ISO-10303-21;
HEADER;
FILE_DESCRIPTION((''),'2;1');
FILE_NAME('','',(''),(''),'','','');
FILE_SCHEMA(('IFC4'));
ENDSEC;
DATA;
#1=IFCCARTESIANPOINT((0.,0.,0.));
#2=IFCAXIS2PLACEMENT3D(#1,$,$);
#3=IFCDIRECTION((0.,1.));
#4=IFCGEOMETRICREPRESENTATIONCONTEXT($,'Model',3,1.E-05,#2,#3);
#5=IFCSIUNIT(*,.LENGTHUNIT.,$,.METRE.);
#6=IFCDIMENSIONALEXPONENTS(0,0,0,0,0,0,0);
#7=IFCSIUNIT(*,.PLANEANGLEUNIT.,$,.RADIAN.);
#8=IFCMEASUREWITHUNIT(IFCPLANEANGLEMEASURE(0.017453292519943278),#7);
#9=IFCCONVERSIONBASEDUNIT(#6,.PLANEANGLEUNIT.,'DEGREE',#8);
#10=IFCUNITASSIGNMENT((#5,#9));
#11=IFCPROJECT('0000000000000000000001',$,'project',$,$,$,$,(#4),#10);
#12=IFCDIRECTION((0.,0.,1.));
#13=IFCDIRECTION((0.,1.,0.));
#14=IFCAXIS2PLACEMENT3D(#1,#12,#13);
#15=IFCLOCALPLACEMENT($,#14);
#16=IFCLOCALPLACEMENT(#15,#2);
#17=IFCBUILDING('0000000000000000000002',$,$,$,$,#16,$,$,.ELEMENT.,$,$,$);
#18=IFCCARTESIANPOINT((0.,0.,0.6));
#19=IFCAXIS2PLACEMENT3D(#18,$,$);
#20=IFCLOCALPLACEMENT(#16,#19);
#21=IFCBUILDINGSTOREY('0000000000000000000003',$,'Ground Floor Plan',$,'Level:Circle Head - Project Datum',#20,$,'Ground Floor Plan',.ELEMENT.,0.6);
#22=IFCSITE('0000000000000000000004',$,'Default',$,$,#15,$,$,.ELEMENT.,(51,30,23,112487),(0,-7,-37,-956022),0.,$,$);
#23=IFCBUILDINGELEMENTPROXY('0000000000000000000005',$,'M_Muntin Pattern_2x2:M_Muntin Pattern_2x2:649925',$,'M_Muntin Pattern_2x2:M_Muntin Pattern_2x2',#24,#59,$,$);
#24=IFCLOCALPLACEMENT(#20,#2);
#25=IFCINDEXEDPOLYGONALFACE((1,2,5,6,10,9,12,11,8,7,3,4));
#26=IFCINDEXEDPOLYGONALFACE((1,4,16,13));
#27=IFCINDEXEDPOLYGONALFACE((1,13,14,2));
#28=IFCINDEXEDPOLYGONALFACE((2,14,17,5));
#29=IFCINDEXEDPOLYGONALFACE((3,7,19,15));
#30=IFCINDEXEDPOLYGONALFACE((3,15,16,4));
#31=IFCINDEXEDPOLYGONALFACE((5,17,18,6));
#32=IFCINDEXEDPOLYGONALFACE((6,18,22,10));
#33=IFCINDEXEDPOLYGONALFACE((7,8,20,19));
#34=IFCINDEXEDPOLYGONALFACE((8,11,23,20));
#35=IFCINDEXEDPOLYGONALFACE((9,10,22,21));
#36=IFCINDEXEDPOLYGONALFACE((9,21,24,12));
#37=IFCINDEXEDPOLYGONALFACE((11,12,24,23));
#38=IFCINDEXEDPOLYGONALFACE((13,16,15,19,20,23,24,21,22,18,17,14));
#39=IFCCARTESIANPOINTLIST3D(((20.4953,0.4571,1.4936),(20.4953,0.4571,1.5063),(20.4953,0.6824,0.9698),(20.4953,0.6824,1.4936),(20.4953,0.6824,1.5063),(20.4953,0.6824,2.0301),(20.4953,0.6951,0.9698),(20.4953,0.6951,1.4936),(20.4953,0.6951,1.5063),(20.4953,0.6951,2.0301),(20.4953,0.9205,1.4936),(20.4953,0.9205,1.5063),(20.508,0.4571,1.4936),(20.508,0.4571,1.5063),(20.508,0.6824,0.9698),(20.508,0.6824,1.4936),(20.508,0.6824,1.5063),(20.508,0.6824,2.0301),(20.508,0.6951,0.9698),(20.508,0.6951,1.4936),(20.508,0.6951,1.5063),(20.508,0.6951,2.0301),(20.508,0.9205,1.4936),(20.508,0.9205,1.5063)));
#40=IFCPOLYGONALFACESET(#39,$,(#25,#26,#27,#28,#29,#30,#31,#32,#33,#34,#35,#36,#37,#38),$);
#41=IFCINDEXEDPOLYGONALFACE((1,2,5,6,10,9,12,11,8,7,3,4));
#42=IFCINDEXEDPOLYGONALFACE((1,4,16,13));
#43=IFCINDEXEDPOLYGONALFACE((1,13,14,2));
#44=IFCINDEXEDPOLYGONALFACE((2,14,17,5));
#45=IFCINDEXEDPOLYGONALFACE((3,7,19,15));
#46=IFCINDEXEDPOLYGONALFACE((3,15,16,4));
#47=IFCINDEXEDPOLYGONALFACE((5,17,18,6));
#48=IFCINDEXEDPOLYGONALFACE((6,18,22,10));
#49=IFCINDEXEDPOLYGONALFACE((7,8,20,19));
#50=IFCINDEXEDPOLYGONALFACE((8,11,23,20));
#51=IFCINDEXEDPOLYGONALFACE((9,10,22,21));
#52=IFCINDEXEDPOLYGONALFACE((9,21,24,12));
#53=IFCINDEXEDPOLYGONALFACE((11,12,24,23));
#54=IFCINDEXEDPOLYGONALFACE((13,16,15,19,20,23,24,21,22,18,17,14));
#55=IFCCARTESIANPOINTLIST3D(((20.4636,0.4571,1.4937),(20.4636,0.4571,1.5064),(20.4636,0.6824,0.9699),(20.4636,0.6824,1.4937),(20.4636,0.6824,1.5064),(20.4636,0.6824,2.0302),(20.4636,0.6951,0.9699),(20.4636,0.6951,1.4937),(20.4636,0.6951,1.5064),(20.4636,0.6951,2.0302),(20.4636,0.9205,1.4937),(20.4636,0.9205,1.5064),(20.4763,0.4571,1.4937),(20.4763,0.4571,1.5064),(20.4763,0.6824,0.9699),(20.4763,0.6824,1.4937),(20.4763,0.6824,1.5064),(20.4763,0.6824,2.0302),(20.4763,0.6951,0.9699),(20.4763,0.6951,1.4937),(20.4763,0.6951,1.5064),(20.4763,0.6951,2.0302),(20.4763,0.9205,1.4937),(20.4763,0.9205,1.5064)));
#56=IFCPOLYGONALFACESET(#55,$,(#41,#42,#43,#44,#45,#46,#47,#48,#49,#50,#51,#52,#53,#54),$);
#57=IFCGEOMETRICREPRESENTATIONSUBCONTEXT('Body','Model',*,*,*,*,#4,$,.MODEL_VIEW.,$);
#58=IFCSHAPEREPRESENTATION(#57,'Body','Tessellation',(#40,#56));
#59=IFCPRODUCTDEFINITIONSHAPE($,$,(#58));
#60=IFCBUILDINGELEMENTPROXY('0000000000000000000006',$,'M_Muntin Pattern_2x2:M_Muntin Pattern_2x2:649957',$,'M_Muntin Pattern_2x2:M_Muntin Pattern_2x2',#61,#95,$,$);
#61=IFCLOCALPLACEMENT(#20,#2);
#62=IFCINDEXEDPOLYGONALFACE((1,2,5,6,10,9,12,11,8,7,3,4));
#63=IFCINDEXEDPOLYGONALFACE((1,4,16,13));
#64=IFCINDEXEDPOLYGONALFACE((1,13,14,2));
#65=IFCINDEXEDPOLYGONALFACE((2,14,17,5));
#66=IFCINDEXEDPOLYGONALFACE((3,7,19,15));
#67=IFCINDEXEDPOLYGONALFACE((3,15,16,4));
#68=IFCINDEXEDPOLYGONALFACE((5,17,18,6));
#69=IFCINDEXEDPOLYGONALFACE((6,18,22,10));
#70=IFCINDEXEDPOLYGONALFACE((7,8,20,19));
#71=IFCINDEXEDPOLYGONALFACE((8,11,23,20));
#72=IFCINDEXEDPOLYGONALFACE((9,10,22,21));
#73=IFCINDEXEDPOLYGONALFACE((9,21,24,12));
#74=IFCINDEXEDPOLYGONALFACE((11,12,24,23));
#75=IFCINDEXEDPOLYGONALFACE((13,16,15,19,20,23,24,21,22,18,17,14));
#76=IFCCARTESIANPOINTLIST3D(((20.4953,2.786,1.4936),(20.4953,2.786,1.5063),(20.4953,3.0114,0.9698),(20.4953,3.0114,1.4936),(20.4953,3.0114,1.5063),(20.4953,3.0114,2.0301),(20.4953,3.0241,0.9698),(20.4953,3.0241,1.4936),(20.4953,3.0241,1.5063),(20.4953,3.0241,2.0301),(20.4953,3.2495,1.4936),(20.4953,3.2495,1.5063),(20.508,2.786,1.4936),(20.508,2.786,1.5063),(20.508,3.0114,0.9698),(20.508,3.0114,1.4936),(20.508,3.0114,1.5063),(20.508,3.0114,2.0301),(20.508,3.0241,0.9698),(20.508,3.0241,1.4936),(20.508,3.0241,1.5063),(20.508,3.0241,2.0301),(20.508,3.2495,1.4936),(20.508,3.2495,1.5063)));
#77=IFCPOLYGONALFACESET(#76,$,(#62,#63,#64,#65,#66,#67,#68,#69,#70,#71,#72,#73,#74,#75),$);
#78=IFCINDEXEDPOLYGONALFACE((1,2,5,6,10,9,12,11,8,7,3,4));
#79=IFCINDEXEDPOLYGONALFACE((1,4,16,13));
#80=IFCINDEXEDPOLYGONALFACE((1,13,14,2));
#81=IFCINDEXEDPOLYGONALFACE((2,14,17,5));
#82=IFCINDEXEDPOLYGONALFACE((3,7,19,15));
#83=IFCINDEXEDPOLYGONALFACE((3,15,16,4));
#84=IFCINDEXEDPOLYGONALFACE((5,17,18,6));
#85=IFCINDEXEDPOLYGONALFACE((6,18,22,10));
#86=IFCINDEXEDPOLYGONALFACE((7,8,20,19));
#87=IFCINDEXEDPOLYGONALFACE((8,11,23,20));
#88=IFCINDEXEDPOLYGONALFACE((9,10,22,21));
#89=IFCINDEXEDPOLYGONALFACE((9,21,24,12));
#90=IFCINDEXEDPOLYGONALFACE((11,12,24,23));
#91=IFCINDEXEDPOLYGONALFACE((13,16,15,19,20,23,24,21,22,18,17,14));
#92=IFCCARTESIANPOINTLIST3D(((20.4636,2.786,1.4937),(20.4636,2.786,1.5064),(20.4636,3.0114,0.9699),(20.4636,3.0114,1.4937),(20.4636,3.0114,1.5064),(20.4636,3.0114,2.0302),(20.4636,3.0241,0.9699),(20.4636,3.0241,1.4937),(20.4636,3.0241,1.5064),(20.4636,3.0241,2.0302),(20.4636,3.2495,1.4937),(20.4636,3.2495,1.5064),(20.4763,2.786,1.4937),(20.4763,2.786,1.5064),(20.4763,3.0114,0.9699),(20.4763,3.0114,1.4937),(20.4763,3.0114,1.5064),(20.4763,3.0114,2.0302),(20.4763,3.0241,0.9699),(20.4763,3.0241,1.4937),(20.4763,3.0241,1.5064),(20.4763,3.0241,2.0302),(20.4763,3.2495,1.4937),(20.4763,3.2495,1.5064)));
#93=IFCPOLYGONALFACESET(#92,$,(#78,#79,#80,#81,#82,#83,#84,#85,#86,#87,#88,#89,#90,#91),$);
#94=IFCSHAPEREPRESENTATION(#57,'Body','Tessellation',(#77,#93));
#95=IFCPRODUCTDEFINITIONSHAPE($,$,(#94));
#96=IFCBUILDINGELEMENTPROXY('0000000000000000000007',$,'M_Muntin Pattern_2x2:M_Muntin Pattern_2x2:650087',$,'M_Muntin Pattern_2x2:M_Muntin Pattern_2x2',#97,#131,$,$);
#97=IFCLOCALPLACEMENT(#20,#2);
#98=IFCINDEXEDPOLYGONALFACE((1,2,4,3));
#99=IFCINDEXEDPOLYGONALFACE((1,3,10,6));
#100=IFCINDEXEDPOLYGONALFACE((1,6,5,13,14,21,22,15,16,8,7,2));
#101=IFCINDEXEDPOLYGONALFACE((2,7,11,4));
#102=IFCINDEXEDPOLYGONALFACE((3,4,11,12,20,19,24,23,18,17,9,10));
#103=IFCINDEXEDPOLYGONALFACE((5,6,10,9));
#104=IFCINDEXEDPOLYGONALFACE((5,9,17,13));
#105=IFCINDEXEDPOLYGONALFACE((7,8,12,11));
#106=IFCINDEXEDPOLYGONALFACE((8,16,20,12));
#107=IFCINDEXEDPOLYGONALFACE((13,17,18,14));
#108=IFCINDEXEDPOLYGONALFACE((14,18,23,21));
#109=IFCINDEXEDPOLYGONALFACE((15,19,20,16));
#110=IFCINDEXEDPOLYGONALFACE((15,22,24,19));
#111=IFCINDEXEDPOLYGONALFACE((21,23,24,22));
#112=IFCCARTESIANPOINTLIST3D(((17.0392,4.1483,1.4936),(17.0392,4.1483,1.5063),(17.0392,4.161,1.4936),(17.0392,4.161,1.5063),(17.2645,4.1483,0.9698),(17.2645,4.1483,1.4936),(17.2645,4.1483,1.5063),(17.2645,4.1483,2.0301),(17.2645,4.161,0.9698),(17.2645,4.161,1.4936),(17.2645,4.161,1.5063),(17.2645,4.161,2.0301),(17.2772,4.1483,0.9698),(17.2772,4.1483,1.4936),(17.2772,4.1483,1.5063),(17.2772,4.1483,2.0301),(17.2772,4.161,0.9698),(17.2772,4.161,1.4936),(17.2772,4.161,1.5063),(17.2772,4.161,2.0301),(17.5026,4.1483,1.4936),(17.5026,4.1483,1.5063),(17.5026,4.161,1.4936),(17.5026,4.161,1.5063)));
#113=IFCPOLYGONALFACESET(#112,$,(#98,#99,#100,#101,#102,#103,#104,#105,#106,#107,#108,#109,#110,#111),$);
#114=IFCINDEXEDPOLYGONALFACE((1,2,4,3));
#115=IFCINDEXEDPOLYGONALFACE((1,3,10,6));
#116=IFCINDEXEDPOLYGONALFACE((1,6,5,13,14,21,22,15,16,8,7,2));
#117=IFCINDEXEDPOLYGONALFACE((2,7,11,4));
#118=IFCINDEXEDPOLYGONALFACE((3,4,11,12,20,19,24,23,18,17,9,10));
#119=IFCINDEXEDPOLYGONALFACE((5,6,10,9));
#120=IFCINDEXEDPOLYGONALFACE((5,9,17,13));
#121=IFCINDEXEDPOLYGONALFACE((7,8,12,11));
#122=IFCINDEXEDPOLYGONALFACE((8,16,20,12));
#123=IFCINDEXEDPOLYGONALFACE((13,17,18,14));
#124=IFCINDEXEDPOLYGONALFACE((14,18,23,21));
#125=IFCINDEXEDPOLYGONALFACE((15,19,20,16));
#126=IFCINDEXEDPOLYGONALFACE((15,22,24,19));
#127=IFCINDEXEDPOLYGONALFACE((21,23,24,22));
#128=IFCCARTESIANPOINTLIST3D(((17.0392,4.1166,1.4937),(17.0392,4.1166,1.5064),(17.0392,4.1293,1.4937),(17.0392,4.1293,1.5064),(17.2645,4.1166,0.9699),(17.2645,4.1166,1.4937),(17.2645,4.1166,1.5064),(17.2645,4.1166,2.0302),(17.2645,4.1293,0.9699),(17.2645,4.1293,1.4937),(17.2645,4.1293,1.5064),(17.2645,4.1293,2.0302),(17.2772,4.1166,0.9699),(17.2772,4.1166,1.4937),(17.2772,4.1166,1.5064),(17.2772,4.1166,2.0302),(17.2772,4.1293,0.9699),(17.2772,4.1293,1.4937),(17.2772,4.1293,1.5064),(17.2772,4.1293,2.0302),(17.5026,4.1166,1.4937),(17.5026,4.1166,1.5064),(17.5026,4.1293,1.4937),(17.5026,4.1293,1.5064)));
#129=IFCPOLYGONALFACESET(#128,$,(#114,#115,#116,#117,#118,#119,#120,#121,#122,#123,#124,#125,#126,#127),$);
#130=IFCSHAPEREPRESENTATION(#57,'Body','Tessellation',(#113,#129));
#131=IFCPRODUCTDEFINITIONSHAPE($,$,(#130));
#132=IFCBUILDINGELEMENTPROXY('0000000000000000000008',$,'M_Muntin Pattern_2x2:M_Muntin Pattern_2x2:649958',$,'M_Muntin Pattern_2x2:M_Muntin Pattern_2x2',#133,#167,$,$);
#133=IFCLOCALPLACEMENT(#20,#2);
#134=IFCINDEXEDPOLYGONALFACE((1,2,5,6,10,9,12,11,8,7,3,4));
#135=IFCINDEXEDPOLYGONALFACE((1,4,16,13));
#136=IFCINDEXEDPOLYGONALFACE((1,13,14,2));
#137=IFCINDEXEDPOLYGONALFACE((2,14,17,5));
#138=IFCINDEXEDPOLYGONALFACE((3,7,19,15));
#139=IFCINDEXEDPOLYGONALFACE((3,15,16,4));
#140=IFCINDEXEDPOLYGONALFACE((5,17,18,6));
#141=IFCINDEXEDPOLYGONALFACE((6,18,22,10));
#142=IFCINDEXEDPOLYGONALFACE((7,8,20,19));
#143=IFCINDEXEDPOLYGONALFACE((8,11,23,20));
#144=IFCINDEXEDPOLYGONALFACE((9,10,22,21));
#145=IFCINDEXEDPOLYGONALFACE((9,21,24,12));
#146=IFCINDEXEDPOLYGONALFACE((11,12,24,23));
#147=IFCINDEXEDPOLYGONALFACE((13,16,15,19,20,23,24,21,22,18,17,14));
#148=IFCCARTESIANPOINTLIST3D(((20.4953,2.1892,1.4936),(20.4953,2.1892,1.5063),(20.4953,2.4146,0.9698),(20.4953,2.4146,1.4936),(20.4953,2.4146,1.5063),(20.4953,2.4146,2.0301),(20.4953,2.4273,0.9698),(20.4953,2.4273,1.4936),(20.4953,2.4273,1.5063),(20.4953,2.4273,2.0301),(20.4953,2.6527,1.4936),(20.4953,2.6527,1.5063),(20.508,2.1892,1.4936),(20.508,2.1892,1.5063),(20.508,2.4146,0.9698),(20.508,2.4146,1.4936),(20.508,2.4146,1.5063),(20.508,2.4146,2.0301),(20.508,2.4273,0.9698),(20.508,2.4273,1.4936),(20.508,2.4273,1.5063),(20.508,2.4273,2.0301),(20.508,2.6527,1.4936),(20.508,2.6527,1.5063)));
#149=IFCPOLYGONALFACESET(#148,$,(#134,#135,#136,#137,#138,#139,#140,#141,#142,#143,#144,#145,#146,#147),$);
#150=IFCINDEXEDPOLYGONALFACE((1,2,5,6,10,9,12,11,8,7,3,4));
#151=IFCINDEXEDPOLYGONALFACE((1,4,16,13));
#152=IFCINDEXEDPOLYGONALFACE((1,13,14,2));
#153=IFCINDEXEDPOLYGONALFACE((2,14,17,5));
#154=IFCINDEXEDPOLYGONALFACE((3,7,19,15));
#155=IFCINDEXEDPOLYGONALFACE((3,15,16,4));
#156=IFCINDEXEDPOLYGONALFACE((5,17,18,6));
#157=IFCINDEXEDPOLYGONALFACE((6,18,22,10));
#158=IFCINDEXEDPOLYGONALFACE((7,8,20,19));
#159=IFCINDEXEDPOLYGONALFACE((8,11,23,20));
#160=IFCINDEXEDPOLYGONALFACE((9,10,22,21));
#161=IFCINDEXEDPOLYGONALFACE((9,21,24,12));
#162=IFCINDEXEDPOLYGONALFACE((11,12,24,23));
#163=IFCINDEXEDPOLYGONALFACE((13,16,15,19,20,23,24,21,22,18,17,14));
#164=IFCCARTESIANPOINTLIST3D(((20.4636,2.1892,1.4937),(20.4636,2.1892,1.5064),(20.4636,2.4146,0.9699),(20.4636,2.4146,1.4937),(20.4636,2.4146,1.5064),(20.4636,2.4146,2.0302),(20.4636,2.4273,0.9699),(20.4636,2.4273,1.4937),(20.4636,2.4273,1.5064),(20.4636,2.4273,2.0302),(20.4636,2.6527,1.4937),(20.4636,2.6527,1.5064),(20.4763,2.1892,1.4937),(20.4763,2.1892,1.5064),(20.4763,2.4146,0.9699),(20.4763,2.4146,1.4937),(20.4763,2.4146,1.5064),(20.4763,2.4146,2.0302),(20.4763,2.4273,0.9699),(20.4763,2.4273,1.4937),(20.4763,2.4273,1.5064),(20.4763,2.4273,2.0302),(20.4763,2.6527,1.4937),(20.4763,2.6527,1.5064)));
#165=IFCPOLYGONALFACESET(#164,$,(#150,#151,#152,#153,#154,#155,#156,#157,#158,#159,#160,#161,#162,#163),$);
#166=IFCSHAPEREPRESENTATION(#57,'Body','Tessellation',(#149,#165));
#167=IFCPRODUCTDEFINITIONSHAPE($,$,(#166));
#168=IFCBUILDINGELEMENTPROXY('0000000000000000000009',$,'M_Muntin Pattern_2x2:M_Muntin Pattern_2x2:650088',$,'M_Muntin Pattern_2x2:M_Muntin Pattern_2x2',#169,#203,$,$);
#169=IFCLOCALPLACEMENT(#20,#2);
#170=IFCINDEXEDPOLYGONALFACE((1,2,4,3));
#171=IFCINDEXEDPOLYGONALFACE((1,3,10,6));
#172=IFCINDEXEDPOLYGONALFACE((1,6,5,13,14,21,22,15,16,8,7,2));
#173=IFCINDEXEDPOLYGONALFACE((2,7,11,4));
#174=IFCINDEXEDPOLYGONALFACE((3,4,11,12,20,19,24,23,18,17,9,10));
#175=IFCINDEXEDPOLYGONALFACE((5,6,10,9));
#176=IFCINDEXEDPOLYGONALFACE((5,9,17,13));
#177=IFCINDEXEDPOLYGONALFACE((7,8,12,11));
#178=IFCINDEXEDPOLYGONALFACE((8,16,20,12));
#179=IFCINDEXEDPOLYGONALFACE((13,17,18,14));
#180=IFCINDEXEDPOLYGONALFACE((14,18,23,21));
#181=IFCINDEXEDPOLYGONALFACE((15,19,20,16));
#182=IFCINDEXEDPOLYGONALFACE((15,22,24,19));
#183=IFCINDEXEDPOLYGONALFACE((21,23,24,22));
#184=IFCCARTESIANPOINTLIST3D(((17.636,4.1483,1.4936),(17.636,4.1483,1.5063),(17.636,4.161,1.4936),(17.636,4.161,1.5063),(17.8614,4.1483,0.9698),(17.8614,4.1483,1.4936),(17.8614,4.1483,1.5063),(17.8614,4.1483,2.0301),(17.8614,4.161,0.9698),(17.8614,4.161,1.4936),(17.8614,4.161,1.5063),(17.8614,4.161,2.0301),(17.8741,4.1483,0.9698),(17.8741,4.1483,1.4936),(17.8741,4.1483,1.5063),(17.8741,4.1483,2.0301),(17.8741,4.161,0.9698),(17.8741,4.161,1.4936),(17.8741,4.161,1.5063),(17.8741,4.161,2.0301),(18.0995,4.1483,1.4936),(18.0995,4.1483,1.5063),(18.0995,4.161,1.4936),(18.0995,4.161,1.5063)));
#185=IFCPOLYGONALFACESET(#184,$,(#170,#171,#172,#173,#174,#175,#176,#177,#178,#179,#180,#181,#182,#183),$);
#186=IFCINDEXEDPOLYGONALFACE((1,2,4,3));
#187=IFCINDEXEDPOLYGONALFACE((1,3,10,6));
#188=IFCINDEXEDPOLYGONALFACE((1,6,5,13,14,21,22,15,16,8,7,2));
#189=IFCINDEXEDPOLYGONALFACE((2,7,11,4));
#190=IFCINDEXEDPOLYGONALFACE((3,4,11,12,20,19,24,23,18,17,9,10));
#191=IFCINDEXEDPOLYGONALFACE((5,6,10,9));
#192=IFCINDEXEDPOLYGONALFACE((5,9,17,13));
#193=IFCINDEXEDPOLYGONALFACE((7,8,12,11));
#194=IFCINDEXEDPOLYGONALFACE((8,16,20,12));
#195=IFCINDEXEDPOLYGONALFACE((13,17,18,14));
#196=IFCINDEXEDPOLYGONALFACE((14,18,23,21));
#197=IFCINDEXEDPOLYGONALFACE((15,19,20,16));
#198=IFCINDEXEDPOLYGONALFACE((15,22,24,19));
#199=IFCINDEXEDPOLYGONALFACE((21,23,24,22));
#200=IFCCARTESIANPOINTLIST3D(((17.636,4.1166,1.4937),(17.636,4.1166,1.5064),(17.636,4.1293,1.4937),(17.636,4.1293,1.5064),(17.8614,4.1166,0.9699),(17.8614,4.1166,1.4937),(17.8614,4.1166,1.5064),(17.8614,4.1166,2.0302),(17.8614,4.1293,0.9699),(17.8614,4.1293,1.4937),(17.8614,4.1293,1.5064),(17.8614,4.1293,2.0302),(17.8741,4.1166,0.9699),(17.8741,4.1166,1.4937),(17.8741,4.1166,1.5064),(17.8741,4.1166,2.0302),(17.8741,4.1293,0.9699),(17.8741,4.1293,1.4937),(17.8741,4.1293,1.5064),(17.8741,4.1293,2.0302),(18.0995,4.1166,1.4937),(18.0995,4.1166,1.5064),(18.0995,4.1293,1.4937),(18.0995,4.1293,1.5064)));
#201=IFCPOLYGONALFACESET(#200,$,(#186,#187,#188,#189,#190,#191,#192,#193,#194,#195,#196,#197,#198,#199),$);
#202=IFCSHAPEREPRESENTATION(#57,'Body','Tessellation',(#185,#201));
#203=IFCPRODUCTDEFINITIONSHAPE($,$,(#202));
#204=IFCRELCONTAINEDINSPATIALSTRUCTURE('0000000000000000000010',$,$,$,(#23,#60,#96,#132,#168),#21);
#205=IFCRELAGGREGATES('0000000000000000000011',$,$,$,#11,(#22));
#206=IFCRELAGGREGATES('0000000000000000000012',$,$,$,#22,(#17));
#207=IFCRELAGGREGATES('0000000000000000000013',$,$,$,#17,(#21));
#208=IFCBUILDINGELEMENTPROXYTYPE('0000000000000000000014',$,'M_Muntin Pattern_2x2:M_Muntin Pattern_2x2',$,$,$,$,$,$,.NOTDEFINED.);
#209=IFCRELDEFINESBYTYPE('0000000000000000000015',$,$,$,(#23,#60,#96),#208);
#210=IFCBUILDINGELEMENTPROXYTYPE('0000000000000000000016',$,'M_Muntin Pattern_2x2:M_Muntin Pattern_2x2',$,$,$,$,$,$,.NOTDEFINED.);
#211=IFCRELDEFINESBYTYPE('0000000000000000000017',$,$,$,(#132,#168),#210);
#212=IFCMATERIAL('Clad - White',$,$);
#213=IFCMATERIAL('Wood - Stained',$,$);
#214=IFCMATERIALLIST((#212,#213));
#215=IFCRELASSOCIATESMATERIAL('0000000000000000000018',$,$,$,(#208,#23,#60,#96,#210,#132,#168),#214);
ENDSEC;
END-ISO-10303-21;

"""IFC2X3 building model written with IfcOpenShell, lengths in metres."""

from ifc_helpers import new_model, entity, si_unit, converted_unit, direction, frame, origin, place, context, subcontext, project, spatial, polyline, outline, extrude, source, transform, mapped, material, material_list, type_object, type_shapes, element, save


model = new_model("IFC2X3")

# Units and contexts
model_context = context("Model", 3, precision=1e-05, world=origin(), true_north=direction((0.0, 1.0)))
body_context = subcontext(model_context, "Body", "Model", "MODEL_VIEW")
ifc_project = project(units=[si_unit("LENGTHUNIT", "METRE"), converted_unit("PLANEANGLEUNIT", "DEGREE", entity("IfcPlaneAngleMeasure", 0.017453292519943278), si_unit("PLANEANGLEUNIT", "RADIAN"), dimensions=[0, 0, 0, 0, 0, 0, 0])], contexts=[model_context])

# Site, building, storey
site_placement = place(None, frame((0.0, 0.0, 0.0), z_axis=(0.0, 0.0, 1.0), x_axis=(0.0, 1.0, 0.0)))
site = spatial("IfcSite", under=ifc_project, at=site_placement, Name="Default", CompositionType="ELEMENT", RefLatitude=(51, 30, 23, 112487), RefLongitude=(0, -7, -37, -956022), RefElevation=0.0)
building_placement = place(site_placement, origin())
building = spatial("IfcBuilding", under=site, at=building_placement, CompositionType="ELEMENT")
storey_placement = place(building_placement, frame((0.0, 0.0, 0.6)))
storey = spatial("IfcBuildingStorey", under=building, at=storey_placement, Name="Ground Floor Plan", ObjectType="Level:Circle Head - Project Datum", LongName="Ground Floor Plan", CompositionType="ELEMENT", Elevation=0.6)

# Building element proxies
ifc_material_1 = material(Name="Clad - White")
ifc_material_2 = material(Name="Wood - Stained")
ifc_material_list = material_list([ifc_material_1, ifc_material_2])
building_element_proxy_type_1 = type_object("IfcBuildingElementProxyType", Name="M_Muntin Pattern_2x2:M_Muntin Pattern_2x2", PredefinedType="NOTDEFINED", material=ifc_material_list)
shared_shape_1 = source(origin(), body_context, "Body", "SweptSolid", [
    extrude(outline(polyline([(0.0064, -0.0064), (0.5301, -0.0064), (0.5301, 0.0063), (0.0064, 0.0063), (0.0064, 0.2317), (-0.0063, 0.2317), (-0.0063, 0.0063), (-0.5302, 0.0063), (-0.5302, -0.0064), (-0.0063, -0.0064), (-0.0063, -0.2317), (0.0064, -0.2317), (0.0064, -0.0064)])), frame((0.0, 0.0095, 0.5301), z_axis=(0.0, 1.0, 0.0), x_axis=(0.0, 0.0, 1.0)), (0.0, 0.0, 1.0), 0.0127),
    extrude(outline(polyline([(0.0064, -0.0064), (0.5302, -0.0064), (0.5302, 0.0063), (0.0064, 0.0063), (0.0064, 0.2317), (-0.0063, 0.2317), (-0.0063, 0.0063), (-0.5302, 0.0063), (-0.5302, -0.0064), (-0.0063, -0.0064), (-0.0063, -0.2317), (0.0064, -0.2317), (0.0064, -0.0064)])), frame((0.0, -0.0222, 0.5302), z_axis=(0.0, 1.0, 0.0), x_axis=(0.0, 0.0, 1.0)), (0.0, 0.0, 1.0), 0.0127),
])
type_shapes(building_element_proxy_type_1, [shared_shape_1])
for number, where, z_axis, x_axis, name in (
    (1, (20.4858, 0.6888, 0.9699), (0.0, 0.0, 1.0), (0.0, -1.0, 0.0), "M_Muntin Pattern_2x2:M_Muntin Pattern_2x2:649925"),
    (2, (20.4858, 3.0178, 0.9699), (0.0, 0.0, 1.0), (0.0, -1.0, 0.0), "M_Muntin Pattern_2x2:M_Muntin Pattern_2x2:649957"),
):
    element("IfcBuildingElementProxy", number, at=place(storey_placement, frame(where, z_axis=z_axis, x_axis=x_axis)), inside=storey, type_object=building_element_proxy_type_1, material=ifc_material_list, Name=name, ObjectType="M_Muntin Pattern_2x2:M_Muntin Pattern_2x2", context=body_context, shape_type="MappedRepresentation", body=[
        mapped(shared_shape_1, transform((0.0, 0.0, 0.0), scale=1.0)),
    ])
proxy_1_placement = place(storey_placement, frame((17.2709, 4.1388, 0.9699)))
element("IfcBuildingElementProxy", 3, at=proxy_1_placement, inside=storey, type_object=building_element_proxy_type_1, material=ifc_material_list, Name="M_Muntin Pattern_2x2:M_Muntin Pattern_2x2:650087", ObjectType="M_Muntin Pattern_2x2:M_Muntin Pattern_2x2", context=body_context, shape_type="MappedRepresentation", body=[
    mapped(shared_shape_1, transform((0.0, 0.0, 0.0), scale=1.0)),
])
building_element_proxy_type_2 = type_object("IfcBuildingElementProxyType", Name="M_Muntin Pattern_2x2:M_Muntin Pattern_2x2", PredefinedType="NOTDEFINED", material=ifc_material_list)
shared_shape_2 = source(origin(), body_context, "Body", "SweptSolid", [
    extrude(outline(polyline([(0.0064, -0.0064), (0.5301, -0.0064), (0.5301, 0.0063), (0.0064, 0.0063), (0.0064, 0.2317), (-0.0063, 0.2317), (-0.0063, 0.0063), (-0.5302, 0.0063), (-0.5302, -0.0064), (-0.0063, -0.0064), (-0.0063, -0.2317), (0.0064, -0.2317), (0.0064, -0.0064)])), frame((0.0, -0.0222, 0.5301), z_axis=(0.0, 1.0, 0.0), x_axis=(0.0, 0.0, 1.0)), (0.0, 0.0, 1.0), 0.0127),
    extrude(outline(polyline([(0.0064, -0.0064), (0.5302, -0.0064), (0.5302, 0.0063), (0.0064, 0.0063), (0.0064, 0.2317), (-0.0063, 0.2317), (-0.0063, 0.0063), (-0.5302, 0.0063), (-0.5302, -0.0064), (-0.0063, -0.0064), (-0.0063, -0.2317), (0.0064, -0.2317), (0.0064, -0.0064)])), frame((0.0, 0.0095, 0.5302), z_axis=(0.0, 1.0, 0.0), x_axis=(0.0, 0.0, 1.0)), (0.0, 0.0, 1.0), 0.0127),
])
type_shapes(building_element_proxy_type_2, [shared_shape_2])
for number, where, z_axis, x_axis, name in (
    (4, (20.4858, 2.4209, 0.9699), (0.0, 0.0, 1.0), (0.0, 1.0, 0.0), "M_Muntin Pattern_2x2:M_Muntin Pattern_2x2:649958"),
    (5, (17.8677, 4.1388, 0.9699), (0.0, 0.0, 1.0), (-1.0, 0.0, 0.0), "M_Muntin Pattern_2x2:M_Muntin Pattern_2x2:650088"),
):
    element("IfcBuildingElementProxy", number, at=place(storey_placement, frame(where, z_axis=z_axis, x_axis=x_axis)), inside=storey, type_object=building_element_proxy_type_2, material=ifc_material_list, Name=name, ObjectType="M_Muntin Pattern_2x2:M_Muntin Pattern_2x2", context=body_context, shape_type="MappedRepresentation", body=[
        mapped(shared_shape_2, transform((0.0, 0.0, 0.0), scale=1.0)),
    ])

save(model, "model.ifc")
